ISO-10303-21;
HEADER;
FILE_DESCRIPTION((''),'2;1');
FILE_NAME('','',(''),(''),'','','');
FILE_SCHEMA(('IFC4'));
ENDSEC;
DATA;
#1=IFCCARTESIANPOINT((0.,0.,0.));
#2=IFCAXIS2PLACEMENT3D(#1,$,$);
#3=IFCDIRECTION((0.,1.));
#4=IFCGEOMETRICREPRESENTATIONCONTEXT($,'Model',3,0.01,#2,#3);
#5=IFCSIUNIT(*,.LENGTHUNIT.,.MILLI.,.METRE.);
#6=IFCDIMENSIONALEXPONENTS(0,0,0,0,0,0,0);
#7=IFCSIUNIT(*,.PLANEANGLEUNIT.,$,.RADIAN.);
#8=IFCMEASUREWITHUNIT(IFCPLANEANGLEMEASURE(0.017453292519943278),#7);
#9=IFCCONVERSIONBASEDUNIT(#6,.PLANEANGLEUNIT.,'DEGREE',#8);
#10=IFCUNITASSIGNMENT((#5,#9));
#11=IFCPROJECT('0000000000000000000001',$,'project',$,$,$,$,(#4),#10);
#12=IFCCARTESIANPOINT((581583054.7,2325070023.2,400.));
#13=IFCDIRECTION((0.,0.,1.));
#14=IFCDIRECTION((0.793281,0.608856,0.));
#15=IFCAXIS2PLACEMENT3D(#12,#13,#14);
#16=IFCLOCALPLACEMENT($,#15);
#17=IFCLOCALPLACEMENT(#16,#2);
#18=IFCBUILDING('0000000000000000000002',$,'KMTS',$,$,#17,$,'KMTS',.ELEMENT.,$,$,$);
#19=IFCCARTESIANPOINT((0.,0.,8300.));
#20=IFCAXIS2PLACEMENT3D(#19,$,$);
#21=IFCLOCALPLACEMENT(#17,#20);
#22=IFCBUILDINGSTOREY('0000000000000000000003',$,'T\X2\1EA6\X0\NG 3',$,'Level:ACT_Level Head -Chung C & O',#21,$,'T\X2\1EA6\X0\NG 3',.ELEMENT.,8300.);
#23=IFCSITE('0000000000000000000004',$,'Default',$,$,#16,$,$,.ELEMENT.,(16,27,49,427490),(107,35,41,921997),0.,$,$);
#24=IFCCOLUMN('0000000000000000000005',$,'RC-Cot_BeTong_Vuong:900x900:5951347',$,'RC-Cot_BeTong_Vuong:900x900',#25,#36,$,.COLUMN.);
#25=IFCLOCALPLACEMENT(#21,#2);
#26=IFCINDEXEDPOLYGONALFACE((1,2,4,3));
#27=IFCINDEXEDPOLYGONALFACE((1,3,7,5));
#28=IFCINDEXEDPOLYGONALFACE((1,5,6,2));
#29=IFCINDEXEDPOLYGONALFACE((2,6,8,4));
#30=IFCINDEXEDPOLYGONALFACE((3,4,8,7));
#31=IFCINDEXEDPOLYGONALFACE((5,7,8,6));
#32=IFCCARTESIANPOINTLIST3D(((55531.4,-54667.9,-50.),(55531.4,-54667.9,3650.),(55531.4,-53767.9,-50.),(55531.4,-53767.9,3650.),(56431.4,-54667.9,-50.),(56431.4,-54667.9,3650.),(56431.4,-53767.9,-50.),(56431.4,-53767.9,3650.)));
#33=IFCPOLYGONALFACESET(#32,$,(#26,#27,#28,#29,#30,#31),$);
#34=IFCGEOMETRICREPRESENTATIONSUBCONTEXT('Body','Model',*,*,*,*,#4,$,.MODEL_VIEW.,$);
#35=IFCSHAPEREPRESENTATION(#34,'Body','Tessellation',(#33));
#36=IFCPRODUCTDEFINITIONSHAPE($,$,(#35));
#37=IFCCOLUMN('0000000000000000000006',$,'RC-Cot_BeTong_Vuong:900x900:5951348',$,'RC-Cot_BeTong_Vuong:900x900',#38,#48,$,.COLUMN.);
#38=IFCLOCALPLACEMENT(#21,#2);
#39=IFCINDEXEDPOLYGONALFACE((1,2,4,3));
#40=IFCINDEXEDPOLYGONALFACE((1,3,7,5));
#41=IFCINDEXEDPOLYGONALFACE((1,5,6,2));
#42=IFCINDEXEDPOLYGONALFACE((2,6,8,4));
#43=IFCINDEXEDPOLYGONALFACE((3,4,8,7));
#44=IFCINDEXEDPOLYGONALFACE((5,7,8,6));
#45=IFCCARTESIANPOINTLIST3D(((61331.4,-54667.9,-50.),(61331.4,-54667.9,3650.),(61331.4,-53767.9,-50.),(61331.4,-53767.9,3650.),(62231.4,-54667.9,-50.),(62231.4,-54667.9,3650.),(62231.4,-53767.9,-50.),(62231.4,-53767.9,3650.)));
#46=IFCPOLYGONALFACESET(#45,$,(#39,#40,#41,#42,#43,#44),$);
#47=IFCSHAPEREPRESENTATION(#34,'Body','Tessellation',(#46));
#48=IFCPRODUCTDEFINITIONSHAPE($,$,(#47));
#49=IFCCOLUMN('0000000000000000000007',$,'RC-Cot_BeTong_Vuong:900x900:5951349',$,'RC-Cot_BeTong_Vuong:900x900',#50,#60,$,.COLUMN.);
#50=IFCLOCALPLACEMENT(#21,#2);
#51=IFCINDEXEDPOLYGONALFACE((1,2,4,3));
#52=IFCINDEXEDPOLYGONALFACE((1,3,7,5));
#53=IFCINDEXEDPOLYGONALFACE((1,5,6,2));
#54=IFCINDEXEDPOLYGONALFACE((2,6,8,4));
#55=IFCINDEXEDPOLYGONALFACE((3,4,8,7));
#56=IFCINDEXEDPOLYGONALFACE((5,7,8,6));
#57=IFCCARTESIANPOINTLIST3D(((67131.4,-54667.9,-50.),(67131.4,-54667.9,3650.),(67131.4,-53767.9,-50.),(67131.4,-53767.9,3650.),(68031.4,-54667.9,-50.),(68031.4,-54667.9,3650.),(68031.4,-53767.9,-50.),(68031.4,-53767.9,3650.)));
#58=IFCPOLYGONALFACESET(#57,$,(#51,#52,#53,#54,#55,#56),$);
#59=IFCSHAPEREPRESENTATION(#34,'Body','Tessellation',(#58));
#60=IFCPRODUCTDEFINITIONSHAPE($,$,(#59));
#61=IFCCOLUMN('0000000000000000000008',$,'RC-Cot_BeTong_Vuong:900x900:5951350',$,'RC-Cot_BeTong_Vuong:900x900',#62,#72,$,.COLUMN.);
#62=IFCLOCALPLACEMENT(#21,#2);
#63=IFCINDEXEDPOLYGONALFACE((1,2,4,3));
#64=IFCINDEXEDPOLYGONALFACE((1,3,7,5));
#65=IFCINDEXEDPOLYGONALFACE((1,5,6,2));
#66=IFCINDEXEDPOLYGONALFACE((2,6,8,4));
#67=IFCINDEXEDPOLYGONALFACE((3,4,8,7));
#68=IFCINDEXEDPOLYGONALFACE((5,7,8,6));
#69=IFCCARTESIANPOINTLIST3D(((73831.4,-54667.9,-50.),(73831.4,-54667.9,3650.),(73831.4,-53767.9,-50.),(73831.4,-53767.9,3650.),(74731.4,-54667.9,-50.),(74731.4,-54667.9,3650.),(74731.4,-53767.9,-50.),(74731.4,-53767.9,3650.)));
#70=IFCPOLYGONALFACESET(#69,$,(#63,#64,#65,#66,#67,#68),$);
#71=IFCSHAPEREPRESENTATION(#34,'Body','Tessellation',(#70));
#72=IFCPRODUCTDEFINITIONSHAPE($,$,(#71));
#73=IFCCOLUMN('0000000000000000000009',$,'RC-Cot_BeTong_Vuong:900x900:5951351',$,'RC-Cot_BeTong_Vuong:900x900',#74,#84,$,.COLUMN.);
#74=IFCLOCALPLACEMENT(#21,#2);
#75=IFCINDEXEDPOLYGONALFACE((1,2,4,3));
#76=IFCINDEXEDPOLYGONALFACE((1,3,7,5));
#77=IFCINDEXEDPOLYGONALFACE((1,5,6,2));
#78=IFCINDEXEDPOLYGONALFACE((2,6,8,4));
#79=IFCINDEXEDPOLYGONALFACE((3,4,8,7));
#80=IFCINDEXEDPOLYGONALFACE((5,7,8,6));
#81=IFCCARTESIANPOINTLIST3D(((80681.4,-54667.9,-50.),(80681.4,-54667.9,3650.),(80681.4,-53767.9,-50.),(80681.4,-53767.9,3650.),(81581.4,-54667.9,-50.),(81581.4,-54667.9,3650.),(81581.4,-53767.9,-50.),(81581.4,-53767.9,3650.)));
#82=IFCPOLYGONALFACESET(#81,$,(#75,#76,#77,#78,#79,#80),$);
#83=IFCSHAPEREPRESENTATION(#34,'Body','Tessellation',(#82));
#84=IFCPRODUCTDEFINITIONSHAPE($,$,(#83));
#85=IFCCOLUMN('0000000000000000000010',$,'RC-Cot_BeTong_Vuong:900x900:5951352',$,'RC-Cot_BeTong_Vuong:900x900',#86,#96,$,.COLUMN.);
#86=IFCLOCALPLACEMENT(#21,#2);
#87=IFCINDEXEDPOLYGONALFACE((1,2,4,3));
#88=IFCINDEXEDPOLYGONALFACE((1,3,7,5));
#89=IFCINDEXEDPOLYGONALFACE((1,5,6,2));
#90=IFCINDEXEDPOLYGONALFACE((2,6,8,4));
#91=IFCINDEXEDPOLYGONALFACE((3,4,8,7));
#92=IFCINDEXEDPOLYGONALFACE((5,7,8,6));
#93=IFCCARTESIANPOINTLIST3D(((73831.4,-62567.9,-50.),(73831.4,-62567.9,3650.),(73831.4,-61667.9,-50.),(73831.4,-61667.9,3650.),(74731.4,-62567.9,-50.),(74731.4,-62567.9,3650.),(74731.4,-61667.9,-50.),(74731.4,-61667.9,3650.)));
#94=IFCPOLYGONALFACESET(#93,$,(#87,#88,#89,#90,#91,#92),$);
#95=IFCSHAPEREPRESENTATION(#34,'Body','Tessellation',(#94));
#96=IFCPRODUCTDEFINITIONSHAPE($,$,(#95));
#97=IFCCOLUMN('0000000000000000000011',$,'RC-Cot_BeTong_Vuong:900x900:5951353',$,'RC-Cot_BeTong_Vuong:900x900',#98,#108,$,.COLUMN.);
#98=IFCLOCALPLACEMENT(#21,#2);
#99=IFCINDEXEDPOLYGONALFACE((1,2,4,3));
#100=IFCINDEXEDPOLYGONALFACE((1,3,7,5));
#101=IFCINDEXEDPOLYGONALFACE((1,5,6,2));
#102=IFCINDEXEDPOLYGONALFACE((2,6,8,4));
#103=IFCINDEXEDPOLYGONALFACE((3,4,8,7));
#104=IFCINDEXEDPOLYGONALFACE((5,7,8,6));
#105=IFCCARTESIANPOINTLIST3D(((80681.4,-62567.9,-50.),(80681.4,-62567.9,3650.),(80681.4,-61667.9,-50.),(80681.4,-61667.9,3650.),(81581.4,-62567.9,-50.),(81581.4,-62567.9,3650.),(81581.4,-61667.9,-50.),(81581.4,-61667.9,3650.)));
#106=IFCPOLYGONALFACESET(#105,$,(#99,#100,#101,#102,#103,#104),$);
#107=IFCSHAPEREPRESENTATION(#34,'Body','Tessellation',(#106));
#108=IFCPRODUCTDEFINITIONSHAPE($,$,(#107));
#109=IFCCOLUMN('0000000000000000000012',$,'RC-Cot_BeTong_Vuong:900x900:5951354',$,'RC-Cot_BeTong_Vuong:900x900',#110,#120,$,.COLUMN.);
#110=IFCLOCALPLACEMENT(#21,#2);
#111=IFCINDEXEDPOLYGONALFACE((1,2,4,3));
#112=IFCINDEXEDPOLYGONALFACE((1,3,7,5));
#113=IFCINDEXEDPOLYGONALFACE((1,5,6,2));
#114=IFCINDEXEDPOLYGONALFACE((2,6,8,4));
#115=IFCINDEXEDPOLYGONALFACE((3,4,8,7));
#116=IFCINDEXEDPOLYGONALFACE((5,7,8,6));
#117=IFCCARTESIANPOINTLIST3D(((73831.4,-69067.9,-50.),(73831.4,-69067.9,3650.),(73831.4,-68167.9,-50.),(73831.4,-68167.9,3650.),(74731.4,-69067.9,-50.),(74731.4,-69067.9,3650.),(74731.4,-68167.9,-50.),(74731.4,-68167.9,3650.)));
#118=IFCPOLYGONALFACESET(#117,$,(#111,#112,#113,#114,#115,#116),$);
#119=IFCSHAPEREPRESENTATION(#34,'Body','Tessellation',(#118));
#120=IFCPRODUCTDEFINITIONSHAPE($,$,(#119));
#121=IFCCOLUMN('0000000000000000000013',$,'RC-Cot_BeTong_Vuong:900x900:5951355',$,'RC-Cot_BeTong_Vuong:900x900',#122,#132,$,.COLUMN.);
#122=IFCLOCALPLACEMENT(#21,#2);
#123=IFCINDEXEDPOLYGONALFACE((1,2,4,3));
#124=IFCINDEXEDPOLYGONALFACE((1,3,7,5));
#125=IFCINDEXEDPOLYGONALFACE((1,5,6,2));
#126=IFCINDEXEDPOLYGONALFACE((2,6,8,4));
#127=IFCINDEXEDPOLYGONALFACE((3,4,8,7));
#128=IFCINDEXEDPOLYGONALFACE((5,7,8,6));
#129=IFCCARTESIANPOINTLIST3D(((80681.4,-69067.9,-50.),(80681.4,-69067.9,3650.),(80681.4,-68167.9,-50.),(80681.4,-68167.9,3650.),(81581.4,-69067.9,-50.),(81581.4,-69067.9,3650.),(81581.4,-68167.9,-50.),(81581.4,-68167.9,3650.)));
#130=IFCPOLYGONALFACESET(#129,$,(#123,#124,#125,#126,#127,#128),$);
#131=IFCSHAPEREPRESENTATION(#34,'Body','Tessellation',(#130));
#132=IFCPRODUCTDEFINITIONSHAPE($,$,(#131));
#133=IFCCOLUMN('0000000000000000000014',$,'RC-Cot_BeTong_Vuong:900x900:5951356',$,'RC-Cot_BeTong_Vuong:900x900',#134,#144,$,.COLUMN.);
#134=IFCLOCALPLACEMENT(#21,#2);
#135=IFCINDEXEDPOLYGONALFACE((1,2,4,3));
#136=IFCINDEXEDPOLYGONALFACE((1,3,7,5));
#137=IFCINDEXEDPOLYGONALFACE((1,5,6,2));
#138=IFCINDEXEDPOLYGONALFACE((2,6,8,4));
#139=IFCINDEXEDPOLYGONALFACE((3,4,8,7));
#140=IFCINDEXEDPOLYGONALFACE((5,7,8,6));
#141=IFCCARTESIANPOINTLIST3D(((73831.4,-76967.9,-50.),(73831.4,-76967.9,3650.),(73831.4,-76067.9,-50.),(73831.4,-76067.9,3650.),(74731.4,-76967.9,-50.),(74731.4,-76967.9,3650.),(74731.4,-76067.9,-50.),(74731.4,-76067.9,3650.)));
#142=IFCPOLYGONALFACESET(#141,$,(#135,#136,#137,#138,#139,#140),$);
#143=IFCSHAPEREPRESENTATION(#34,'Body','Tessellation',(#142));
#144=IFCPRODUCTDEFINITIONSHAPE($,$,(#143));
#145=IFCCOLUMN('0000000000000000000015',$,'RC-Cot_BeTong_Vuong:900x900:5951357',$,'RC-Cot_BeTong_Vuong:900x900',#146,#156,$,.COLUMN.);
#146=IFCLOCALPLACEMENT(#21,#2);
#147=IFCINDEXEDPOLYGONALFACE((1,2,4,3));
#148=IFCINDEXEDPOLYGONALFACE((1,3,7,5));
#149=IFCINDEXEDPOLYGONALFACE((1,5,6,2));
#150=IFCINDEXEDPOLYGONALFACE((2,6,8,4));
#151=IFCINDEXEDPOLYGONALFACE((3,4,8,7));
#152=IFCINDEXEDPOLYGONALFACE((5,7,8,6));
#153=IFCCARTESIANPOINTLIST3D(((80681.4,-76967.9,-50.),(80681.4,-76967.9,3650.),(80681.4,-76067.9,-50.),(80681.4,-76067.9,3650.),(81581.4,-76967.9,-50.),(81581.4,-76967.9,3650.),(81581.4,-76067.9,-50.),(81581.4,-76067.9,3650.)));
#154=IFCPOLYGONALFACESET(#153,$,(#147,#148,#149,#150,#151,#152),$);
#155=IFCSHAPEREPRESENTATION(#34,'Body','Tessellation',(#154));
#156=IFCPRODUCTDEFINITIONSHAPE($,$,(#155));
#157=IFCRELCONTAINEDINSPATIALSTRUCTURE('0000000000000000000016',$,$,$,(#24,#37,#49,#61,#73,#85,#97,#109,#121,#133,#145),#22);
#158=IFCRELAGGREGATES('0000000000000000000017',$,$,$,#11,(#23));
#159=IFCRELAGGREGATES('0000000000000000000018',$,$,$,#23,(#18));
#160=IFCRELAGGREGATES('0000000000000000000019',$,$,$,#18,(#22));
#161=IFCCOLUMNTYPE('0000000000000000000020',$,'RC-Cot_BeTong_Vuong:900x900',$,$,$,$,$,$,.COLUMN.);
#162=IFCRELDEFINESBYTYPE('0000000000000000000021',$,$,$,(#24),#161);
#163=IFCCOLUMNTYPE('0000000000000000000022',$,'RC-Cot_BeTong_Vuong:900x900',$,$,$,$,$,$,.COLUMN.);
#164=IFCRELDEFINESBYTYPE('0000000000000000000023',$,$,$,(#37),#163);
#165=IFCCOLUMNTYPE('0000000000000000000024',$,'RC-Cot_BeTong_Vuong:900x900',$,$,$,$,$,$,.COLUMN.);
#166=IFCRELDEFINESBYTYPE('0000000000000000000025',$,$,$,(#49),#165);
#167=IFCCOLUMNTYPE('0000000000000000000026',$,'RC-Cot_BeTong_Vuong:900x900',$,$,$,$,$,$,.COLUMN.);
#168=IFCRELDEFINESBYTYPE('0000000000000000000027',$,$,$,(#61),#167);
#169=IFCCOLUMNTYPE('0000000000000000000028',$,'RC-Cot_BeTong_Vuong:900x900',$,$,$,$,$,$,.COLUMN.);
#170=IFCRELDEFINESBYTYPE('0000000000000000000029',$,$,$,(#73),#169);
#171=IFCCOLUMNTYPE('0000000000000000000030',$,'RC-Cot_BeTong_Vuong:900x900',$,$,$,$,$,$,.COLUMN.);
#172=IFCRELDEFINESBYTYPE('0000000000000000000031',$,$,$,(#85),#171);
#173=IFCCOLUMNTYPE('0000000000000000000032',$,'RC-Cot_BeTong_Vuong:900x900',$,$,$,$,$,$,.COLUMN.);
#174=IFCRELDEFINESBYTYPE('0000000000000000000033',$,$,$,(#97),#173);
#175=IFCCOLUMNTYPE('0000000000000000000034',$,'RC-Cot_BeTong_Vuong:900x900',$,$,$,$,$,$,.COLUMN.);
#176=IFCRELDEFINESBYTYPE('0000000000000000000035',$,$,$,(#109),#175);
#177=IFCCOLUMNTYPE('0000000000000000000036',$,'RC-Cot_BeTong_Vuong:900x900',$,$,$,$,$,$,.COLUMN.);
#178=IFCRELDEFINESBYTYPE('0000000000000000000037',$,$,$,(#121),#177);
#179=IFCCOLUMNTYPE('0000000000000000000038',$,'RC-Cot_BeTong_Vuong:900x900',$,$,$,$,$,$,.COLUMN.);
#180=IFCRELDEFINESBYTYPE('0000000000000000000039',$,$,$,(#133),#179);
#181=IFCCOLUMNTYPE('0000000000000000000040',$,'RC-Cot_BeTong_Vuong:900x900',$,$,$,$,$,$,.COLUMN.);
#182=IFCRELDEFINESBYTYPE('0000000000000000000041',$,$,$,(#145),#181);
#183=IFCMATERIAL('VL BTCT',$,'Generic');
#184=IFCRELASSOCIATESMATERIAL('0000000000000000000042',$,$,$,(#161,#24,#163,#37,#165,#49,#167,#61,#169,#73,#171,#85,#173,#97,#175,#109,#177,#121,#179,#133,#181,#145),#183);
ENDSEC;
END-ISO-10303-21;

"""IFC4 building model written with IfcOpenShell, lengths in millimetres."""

from ifc_helpers import new_model, entity, si_unit, converted_unit, direction, frame, origin, place, context, subcontext, project, spatial, indexed_curve, outline, extrude, source, transform, mapped, material, type_object, type_shapes, element, save


model = new_model("IFC4")

# Units and contexts
model_context = context("Model", 3, precision=0.01, world=origin(), true_north=direction((0.0, 1.0)))
body_context = subcontext(model_context, "Body", "Model", "MODEL_VIEW")
ifc_project = project(units=[si_unit("LENGTHUNIT", "METRE", prefix="MILLI"), converted_unit("PLANEANGLEUNIT", "DEGREE", entity("IfcPlaneAngleMeasure", 0.017453292519943278), si_unit("PLANEANGLEUNIT", "RADIAN"), dimensions=[0, 0, 0, 0, 0, 0, 0])], contexts=[model_context])

# Site, building, storey
site_placement = place(None, frame((581583054.7, 2325070023.2, 400.0), z_axis=(0.0, 0.0, 1.0), x_axis=(0.793281, 0.608856, 0.0)))
site = spatial("IfcSite", under=ifc_project, at=site_placement, Name="Default", CompositionType="ELEMENT", RefLatitude=(16, 27, 49, 427490), RefLongitude=(107, 35, 41, 921997), RefElevation=0.0)
building_placement = place(site_placement, origin())
building = spatial("IfcBuilding", under=site, at=building_placement, Name="KMTS", LongName="KMTS", CompositionType="ELEMENT")
storey_placement = place(building_placement, frame((0.0, 0.0, 8300.0)))
storey = spatial("IfcBuildingStorey", under=building, at=storey_placement, Name="TẦNG 3", ObjectType="Level:ACT_Level Head -Chung C & O", LongName="TẦNG 3", CompositionType="ELEMENT", Elevation=8300.0)

# Columns
ifc_material_1 = material(Name="VL BTCT", Category="Generic")
column_type_1 = type_object("IfcColumnType", Name="RC-Cot_BeTong_Vuong:900x900", PredefinedType="COLUMN", material=ifc_material_1)
shared_shape_1 = source(origin(), body_context, "Body", "SweptSolid", [
    extrude(outline(indexed_curve([(-450.0, -450.0), (450.0, -450.0), (450.0, 450.0), (-450.0, 450.0), (-450.0, -450.0)], self_intersect=False)), frame((55981.4, -54217.9, 8250.0), z_axis=(0.0, 0.0, 1.0), x_axis=(-1.0, 0.0, 0.0)), (0.0, 0.0, 1.0), 3700.0),
])
type_shapes(column_type_1, [shared_shape_1])
column_1_placement = place(storey_placement, frame((0.0, 0.0, -8300.0)))
element("IfcColumn", 1, at=column_1_placement, inside=storey, type_object=column_type_1, material=ifc_material_1, Name="RC-Cot_BeTong_Vuong:900x900:5951347", ObjectType="RC-Cot_BeTong_Vuong:900x900", PredefinedType="COLUMN", context=body_context, shape_type="MappedRepresentation", body=[
    mapped(shared_shape_1, transform((0.0, 0.0, 0.0), scale=1.0)),
])
column_type_2 = type_object("IfcColumnType", Name="RC-Cot_BeTong_Vuong:900x900", PredefinedType="COLUMN", material=ifc_material_1)
shared_shape_2 = source(origin(), body_context, "Body", "SweptSolid", [
    extrude(outline(indexed_curve([(-450.0, -450.0), (450.0, -450.0), (450.0, 450.0), (-450.0, 450.0), (-450.0, -450.0)], self_intersect=False)), frame((61781.4, -54217.9, 8250.0), z_axis=(0.0, 0.0, 1.0), x_axis=(-1.0, 0.0, 0.0)), (0.0, 0.0, 1.0), 3700.0),
])
type_shapes(column_type_2, [shared_shape_2])
column_2_placement = place(storey_placement, frame((0.0, 0.0, -8300.0)))
element("IfcColumn", 2, at=column_2_placement, inside=storey, type_object=column_type_2, material=ifc_material_1, Name="RC-Cot_BeTong_Vuong:900x900:5951348", ObjectType="RC-Cot_BeTong_Vuong:900x900", PredefinedType="COLUMN", context=body_context, shape_type="MappedRepresentation", body=[
    mapped(shared_shape_2, transform((0.0, 0.0, 0.0), scale=1.0)),
])
column_type_3 = type_object("IfcColumnType", Name="RC-Cot_BeTong_Vuong:900x900", PredefinedType="COLUMN", material=ifc_material_1)
shared_shape_3 = source(origin(), body_context, "Body", "SweptSolid", [
    extrude(outline(indexed_curve([(-450.0, -450.0), (450.0, -450.0), (450.0, 450.0), (-450.0, 450.0), (-450.0, -450.0)], self_intersect=False)), frame((67581.4, -54217.9, 8250.0), z_axis=(0.0, 0.0, 1.0), x_axis=(-1.0, 0.0, 0.0)), (0.0, 0.0, 1.0), 3700.0),
])
type_shapes(column_type_3, [shared_shape_3])
column_3_placement = place(storey_placement, frame((0.0, 0.0, -8300.0)))
element("IfcColumn", 3, at=column_3_placement, inside=storey, type_object=column_type_3, material=ifc_material_1, Name="RC-Cot_BeTong_Vuong:900x900:5951349", ObjectType="RC-Cot_BeTong_Vuong:900x900", PredefinedType="COLUMN", context=body_context, shape_type="MappedRepresentation", body=[
    mapped(shared_shape_3, transform((0.0, 0.0, 0.0), scale=1.0)),
])
column_type_4 = type_object("IfcColumnType", Name="RC-Cot_BeTong_Vuong:900x900", PredefinedType="COLUMN", material=ifc_material_1)
shared_shape_4 = source(origin(), body_context, "Body", "SweptSolid", [
    extrude(outline(indexed_curve([(-450.0, -450.0), (450.0, -450.0), (450.0, 450.0), (-450.0, 450.0), (-450.0, -450.0)], self_intersect=False)), frame((74281.4, -54217.9, 8250.0), z_axis=(0.0, 0.0, 1.0), x_axis=(-1.0, 0.0, 0.0)), (0.0, 0.0, 1.0), 3700.0),
])
type_shapes(column_type_4, [shared_shape_4])
column_4_placement = place(storey_placement, frame((0.0, 0.0, -8300.0)))
element("IfcColumn", 4, at=column_4_placement, inside=storey, type_object=column_type_4, material=ifc_material_1, Name="RC-Cot_BeTong_Vuong:900x900:5951350", ObjectType="RC-Cot_BeTong_Vuong:900x900", PredefinedType="COLUMN", context=body_context, shape_type="MappedRepresentation", body=[
    mapped(shared_shape_4, transform((0.0, 0.0, 0.0), scale=1.0)),
])
column_type_5 = type_object("IfcColumnType", Name="RC-Cot_BeTong_Vuong:900x900", PredefinedType="COLUMN", material=ifc_material_1)
shared_shape_5 = source(origin(), body_context, "Body", "SweptSolid", [
    extrude(outline(indexed_curve([(-450.0, -450.0), (450.0, -450.0), (450.0, 450.0), (-450.0, 450.0), (-450.0, -450.0)], self_intersect=False)), frame((81131.4, -54217.9, 8250.0), z_axis=(0.0, 0.0, 1.0), x_axis=(-1.0, 0.0, 0.0)), (0.0, 0.0, 1.0), 3700.0),
])
type_shapes(column_type_5, [shared_shape_5])
column_5_placement = place(storey_placement, frame((0.0, 0.0, -8300.0)))
element("IfcColumn", 5, at=column_5_placement, inside=storey, type_object=column_type_5, material=ifc_material_1, Name="RC-Cot_BeTong_Vuong:900x900:5951351", ObjectType="RC-Cot_BeTong_Vuong:900x900", PredefinedType="COLUMN", context=body_context, shape_type="MappedRepresentation", body=[
    mapped(shared_shape_5, transform((0.0, 0.0, 0.0), scale=1.0)),
])
column_type_6 = type_object("IfcColumnType", Name="RC-Cot_BeTong_Vuong:900x900", PredefinedType="COLUMN", material=ifc_material_1)
shared_shape_6 = source(origin(), body_context, "Body", "SweptSolid", [
    extrude(outline(indexed_curve([(-450.0, -450.0), (450.0, -450.0), (450.0, 450.0), (-450.0, 450.0), (-450.0, -450.0)], self_intersect=False)), frame((74281.4, -62117.9, 8250.0), z_axis=(0.0, 0.0, 1.0), x_axis=(-1.0, 0.0, 0.0)), (0.0, 0.0, 1.0), 3700.0),
])
type_shapes(column_type_6, [shared_shape_6])
column_6_placement = place(storey_placement, frame((0.0, 0.0, -8300.0)))
element("IfcColumn", 6, at=column_6_placement, inside=storey, type_object=column_type_6, material=ifc_material_1, Name="RC-Cot_BeTong_Vuong:900x900:5951352", ObjectType="RC-Cot_BeTong_Vuong:900x900", PredefinedType="COLUMN", context=body_context, shape_type="MappedRepresentation", body=[
    mapped(shared_shape_6, transform((0.0, 0.0, 0.0), scale=1.0)),
])
column_type_7 = type_object("IfcColumnType", Name="RC-Cot_BeTong_Vuong:900x900", PredefinedType="COLUMN", material=ifc_material_1)
shared_shape_7 = source(origin(), body_context, "Body", "SweptSolid", [
    extrude(outline(indexed_curve([(-450.0, -450.0), (450.0, -450.0), (450.0, 450.0), (-450.0, 450.0), (-450.0, -450.0)], self_intersect=False)), frame((81131.4, -62117.9, 8250.0), z_axis=(0.0, 0.0, 1.0), x_axis=(-1.0, 0.0, 0.0)), (0.0, 0.0, 1.0), 3700.0),
])
type_shapes(column_type_7, [shared_shape_7])
column_7_placement = place(storey_placement, frame((0.0, 0.0, -8300.0)))
element("IfcColumn", 7, at=column_7_placement, inside=storey, type_object=column_type_7, material=ifc_material_1, Name="RC-Cot_BeTong_Vuong:900x900:5951353", ObjectType="RC-Cot_BeTong_Vuong:900x900", PredefinedType="COLUMN", context=body_context, shape_type="MappedRepresentation", body=[
    mapped(shared_shape_7, transform((0.0, 0.0, 0.0), scale=1.0)),
])
column_type_8 = type_object("IfcColumnType", Name="RC-Cot_BeTong_Vuong:900x900", PredefinedType="COLUMN", material=ifc_material_1)
shared_shape_8 = source(origin(), body_context, "Body", "SweptSolid", [
    extrude(outline(indexed_curve([(-450.0, -450.0), (450.0, -450.0), (450.0, 450.0), (-450.0, 450.0), (-450.0, -450.0)], self_intersect=False)), frame((74281.4, -68617.9, 8250.0), z_axis=(0.0, 0.0, 1.0), x_axis=(-1.0, 0.0, 0.0)), (0.0, 0.0, 1.0), 3700.0),
])
type_shapes(column_type_8, [shared_shape_8])
column_8_placement = place(storey_placement, frame((0.0, 0.0, -8300.0)))
element("IfcColumn", 8, at=column_8_placement, inside=storey, type_object=column_type_8, material=ifc_material_1, Name="RC-Cot_BeTong_Vuong:900x900:5951354", ObjectType="RC-Cot_BeTong_Vuong:900x900", PredefinedType="COLUMN", context=body_context, shape_type="MappedRepresentation", body=[
    mapped(shared_shape_8, transform((0.0, 0.0, 0.0), scale=1.0)),
])
column_type_9 = type_object("IfcColumnType", Name="RC-Cot_BeTong_Vuong:900x900", PredefinedType="COLUMN", material=ifc_material_1)
shared_shape_9 = source(origin(), body_context, "Body", "SweptSolid", [
    extrude(outline(indexed_curve([(-450.0, -450.0), (450.0, -450.0), (450.0, 450.0), (-450.0, 450.0), (-450.0, -450.0)], self_intersect=False)), frame((81131.4, -68617.9, 8250.0), z_axis=(0.0, 0.0, 1.0), x_axis=(-1.0, 0.0, 0.0)), (0.0, 0.0, 1.0), 3700.0),
])
type_shapes(column_type_9, [shared_shape_9])
column_9_placement = place(storey_placement, frame((0.0, 0.0, -8300.0)))
element("IfcColumn", 9, at=column_9_placement, inside=storey, type_object=column_type_9, material=ifc_material_1, Name="RC-Cot_BeTong_Vuong:900x900:5951355", ObjectType="RC-Cot_BeTong_Vuong:900x900", PredefinedType="COLUMN", context=body_context, shape_type="MappedRepresentation", body=[
    mapped(shared_shape_9, transform((0.0, 0.0, 0.0), scale=1.0)),
])
column_type_10 = type_object("IfcColumnType", Name="RC-Cot_BeTong_Vuong:900x900", PredefinedType="COLUMN", material=ifc_material_1)
shared_shape_10 = source(origin(), body_context, "Body", "SweptSolid", [
    extrude(outline(indexed_curve([(-450.0, -450.0), (450.0, -450.0), (450.0, 450.0), (-450.0, 450.0), (-450.0, -450.0)], self_intersect=False)), frame((74281.4, -76517.9, 8250.0), z_axis=(0.0, 0.0, 1.0), x_axis=(-1.0, 0.0, 0.0)), (0.0, 0.0, 1.0), 3700.0),
])
type_shapes(column_type_10, [shared_shape_10])
column_10_placement = place(storey_placement, frame((0.0, 0.0, -8300.0)))
element("IfcColumn", 10, at=column_10_placement, inside=storey, type_object=column_type_10, material=ifc_material_1, Name="RC-Cot_BeTong_Vuong:900x900:5951356", ObjectType="RC-Cot_BeTong_Vuong:900x900", PredefinedType="COLUMN", context=body_context, shape_type="MappedRepresentation", body=[
    mapped(shared_shape_10, transform((0.0, 0.0, 0.0), scale=1.0)),
])
column_type_11 = type_object("IfcColumnType", Name="RC-Cot_BeTong_Vuong:900x900", PredefinedType="COLUMN", material=ifc_material_1)
shared_shape_11 = source(origin(), body_context, "Body", "SweptSolid", [
    extrude(outline(indexed_curve([(-450.0, -450.0), (450.0, -450.0), (450.0, 450.0), (-450.0, 450.0), (-450.0, -450.0)], self_intersect=False)), frame((81131.4, -76517.9, 8250.0), z_axis=(0.0, 0.0, 1.0), x_axis=(-1.0, 0.0, 0.0)), (0.0, 0.0, 1.0), 3700.0),
])
type_shapes(column_type_11, [shared_shape_11])
column_11_placement = place(storey_placement, frame((0.0, 0.0, -8300.0)))
element("IfcColumn", 11, at=column_11_placement, inside=storey, type_object=column_type_11, material=ifc_material_1, Name="RC-Cot_BeTong_Vuong:900x900:5951357", ObjectType="RC-Cot_BeTong_Vuong:900x900", PredefinedType="COLUMN", context=body_context, shape_type="MappedRepresentation", body=[
    mapped(shared_shape_11, transform((0.0, 0.0, 0.0), scale=1.0)),
])

save(model, "model.ifc")
